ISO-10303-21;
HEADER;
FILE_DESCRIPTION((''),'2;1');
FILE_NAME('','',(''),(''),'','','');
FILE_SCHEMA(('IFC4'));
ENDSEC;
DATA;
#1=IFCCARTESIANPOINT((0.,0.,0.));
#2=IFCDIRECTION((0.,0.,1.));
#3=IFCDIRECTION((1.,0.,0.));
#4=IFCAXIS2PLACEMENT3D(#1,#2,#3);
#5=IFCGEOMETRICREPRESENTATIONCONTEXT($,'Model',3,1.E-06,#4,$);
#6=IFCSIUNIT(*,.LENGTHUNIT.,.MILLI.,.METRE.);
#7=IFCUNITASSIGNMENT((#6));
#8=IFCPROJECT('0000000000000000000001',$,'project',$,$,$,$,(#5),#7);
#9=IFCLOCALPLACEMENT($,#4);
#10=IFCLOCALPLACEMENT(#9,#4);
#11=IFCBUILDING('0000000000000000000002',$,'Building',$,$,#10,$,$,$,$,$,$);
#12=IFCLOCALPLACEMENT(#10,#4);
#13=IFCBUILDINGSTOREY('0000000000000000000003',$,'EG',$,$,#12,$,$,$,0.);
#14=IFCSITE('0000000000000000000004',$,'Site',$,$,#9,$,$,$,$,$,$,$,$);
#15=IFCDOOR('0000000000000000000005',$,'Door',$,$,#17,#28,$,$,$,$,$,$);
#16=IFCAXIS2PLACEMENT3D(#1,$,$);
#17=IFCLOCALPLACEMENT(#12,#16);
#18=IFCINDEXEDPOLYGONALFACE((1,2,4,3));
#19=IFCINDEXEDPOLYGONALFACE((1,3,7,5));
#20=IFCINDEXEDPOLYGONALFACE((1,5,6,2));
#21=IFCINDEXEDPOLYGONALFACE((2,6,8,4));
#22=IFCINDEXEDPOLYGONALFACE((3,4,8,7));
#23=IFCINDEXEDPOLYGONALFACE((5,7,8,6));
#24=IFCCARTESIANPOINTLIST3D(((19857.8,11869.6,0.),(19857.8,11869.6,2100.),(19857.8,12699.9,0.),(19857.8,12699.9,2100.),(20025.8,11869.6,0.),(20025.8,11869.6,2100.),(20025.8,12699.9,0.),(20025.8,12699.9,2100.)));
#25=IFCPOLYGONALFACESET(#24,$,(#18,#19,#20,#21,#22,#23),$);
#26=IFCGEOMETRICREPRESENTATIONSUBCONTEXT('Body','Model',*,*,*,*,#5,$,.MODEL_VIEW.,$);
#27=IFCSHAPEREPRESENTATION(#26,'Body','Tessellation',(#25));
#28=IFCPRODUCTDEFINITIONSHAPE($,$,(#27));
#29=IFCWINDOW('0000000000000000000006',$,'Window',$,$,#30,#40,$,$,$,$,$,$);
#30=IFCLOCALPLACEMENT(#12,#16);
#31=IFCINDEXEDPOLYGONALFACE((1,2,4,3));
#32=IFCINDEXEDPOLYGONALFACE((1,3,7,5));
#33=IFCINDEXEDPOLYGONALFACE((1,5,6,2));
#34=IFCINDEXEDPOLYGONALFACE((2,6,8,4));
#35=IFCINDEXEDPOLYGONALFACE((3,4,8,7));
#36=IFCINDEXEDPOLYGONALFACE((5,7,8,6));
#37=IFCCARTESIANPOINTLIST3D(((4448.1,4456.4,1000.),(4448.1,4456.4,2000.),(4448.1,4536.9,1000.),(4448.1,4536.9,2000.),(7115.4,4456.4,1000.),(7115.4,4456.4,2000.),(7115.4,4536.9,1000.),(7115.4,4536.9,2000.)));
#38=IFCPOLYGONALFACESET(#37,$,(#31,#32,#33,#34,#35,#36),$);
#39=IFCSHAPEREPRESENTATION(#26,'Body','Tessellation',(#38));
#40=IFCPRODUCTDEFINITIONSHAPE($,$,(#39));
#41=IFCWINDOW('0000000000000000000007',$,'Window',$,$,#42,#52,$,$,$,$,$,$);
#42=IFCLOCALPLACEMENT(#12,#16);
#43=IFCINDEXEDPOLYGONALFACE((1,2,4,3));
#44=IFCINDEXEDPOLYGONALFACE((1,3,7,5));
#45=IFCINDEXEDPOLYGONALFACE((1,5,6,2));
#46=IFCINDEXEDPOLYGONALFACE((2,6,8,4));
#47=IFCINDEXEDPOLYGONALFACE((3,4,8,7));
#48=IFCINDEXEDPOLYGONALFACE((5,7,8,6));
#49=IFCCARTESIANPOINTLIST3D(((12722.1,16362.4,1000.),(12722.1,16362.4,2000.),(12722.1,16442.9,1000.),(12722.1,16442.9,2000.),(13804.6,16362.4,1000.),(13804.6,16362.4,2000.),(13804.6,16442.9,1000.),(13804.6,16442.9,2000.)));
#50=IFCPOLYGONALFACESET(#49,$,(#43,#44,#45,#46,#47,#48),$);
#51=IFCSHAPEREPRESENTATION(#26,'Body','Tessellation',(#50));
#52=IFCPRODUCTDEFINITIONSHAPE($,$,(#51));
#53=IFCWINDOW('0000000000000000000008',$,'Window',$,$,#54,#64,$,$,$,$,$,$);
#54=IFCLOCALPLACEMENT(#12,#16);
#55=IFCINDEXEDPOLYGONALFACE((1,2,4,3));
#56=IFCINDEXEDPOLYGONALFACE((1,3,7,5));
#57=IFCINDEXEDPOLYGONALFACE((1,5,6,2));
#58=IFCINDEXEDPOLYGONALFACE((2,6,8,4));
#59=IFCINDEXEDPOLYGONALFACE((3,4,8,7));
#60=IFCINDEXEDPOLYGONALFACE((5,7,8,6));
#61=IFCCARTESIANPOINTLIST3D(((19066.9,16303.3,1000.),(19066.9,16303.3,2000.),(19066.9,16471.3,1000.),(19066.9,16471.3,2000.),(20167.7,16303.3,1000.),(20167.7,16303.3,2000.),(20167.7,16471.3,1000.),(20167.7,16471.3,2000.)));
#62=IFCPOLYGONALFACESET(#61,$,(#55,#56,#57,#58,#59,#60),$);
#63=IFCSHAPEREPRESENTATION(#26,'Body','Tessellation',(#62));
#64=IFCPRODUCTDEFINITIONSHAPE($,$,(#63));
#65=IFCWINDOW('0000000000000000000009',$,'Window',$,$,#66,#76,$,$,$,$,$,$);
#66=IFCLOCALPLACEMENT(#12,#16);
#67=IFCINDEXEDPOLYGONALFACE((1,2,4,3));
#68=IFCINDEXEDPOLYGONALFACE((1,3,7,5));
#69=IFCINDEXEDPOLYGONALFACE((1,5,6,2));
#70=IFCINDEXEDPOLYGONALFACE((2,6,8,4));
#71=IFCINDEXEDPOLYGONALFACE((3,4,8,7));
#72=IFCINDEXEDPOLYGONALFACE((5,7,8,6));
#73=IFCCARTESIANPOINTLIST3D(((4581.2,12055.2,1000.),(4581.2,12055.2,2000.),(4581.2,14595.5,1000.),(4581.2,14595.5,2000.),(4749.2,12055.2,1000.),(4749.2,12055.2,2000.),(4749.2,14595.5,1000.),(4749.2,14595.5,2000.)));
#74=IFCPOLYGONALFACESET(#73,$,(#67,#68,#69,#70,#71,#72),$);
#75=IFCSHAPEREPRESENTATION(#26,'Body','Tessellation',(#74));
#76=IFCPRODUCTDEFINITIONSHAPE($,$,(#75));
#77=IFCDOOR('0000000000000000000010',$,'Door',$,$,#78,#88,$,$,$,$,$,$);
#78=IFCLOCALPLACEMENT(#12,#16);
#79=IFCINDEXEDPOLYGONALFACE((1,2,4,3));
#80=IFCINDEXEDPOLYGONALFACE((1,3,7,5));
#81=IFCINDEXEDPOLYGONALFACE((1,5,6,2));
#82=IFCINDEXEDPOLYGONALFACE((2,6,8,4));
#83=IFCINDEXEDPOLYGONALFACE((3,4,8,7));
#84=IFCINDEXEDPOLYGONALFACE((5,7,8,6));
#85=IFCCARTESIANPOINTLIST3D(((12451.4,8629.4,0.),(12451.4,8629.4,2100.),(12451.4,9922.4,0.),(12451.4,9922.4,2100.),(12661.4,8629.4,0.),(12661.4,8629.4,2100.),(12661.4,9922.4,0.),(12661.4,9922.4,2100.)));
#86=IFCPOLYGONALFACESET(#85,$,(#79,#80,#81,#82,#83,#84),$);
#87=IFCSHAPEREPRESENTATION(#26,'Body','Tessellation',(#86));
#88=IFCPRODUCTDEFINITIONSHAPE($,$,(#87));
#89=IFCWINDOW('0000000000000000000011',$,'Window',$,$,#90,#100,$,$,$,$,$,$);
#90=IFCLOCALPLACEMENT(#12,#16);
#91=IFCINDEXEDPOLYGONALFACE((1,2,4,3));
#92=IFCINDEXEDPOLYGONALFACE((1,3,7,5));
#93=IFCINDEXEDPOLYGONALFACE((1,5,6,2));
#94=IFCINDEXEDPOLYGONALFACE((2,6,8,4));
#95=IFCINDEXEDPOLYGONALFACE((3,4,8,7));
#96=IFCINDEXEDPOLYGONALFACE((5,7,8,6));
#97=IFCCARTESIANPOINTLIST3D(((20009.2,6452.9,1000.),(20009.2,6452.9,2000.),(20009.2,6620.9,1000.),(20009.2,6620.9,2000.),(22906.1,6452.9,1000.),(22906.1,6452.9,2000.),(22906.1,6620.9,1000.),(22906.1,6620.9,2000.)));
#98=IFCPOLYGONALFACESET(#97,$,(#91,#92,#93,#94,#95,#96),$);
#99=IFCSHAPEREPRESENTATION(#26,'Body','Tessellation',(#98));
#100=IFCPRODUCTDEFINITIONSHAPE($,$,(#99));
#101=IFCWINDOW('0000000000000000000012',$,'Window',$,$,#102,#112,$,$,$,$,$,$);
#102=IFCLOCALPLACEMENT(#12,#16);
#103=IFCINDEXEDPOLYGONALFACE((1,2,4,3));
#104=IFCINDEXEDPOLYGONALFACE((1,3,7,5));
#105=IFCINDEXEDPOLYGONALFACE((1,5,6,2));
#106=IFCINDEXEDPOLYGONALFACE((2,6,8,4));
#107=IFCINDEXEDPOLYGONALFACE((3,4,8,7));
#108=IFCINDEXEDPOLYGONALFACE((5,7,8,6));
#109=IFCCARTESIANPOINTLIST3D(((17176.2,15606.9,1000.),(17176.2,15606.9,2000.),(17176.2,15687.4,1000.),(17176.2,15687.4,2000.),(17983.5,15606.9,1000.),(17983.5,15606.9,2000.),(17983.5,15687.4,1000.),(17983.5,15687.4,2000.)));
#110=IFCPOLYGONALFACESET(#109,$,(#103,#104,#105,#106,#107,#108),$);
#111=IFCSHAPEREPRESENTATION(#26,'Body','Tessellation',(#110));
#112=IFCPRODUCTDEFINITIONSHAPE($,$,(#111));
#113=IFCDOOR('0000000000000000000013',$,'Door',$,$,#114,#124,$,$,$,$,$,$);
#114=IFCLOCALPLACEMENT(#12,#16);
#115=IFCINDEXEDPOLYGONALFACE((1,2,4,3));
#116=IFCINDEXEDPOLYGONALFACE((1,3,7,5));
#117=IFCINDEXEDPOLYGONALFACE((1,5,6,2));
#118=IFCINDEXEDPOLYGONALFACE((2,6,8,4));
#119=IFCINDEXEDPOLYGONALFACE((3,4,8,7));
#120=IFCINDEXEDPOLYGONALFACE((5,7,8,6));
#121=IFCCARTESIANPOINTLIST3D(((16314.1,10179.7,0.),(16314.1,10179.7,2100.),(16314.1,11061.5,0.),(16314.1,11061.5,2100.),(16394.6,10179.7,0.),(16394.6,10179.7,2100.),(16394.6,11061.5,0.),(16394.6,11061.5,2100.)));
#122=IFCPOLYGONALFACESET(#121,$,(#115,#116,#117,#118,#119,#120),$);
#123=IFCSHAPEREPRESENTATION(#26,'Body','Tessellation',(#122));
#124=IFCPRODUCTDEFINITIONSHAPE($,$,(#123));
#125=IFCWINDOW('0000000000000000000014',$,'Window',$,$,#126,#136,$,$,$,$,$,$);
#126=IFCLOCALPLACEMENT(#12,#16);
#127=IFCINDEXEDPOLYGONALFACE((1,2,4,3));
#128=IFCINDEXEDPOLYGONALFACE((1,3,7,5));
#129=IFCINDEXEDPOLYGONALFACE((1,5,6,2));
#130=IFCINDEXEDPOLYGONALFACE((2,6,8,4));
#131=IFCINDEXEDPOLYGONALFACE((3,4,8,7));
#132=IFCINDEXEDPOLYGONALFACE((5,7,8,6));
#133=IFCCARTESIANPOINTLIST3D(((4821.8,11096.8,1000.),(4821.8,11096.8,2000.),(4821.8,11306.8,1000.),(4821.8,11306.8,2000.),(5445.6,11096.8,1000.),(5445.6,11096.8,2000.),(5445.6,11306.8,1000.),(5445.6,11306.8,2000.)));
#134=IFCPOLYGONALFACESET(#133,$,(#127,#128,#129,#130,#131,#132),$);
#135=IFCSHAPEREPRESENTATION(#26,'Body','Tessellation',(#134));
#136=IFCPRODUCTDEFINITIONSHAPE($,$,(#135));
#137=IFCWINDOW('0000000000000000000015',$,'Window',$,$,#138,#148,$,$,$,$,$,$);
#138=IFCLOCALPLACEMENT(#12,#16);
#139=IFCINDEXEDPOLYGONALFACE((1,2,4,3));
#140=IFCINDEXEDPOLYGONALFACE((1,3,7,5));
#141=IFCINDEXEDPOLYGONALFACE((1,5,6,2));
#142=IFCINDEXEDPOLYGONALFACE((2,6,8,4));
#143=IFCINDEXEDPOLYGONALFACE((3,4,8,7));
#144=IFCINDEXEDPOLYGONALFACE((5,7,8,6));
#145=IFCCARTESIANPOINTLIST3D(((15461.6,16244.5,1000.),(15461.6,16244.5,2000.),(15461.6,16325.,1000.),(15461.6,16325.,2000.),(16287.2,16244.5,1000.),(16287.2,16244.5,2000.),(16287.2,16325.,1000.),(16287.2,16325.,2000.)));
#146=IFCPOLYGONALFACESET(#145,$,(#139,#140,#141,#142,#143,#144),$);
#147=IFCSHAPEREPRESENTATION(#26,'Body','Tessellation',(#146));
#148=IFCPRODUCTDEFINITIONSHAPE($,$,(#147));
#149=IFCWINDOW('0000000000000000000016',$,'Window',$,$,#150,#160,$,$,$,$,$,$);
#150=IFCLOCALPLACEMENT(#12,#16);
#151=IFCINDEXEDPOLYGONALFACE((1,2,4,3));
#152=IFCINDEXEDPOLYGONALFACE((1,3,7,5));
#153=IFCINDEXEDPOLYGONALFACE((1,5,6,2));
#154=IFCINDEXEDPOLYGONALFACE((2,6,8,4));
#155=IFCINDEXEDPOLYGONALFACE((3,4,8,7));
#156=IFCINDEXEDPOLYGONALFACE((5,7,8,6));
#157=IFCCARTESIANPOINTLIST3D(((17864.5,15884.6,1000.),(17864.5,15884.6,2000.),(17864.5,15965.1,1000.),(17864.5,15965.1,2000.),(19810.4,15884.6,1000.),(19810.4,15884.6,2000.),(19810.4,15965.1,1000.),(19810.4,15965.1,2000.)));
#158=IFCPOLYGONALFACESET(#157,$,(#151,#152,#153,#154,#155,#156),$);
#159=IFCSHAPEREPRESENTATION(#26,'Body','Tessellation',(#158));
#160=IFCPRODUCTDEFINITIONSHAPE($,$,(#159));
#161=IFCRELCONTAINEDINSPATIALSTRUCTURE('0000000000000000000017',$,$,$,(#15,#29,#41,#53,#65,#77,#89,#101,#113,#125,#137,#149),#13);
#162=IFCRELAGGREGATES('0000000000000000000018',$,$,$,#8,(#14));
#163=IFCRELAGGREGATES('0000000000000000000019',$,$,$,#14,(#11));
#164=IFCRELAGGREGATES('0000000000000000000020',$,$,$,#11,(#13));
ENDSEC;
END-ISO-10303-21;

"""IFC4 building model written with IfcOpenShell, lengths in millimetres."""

from ifc_helpers import new_model, si_unit, frame, origin_with_axes, place, context, subcontext, project, spatial, rectangle, extrude, element, save


model = new_model("IFC4")

# Units and contexts
model_context = context("Model", 3, precision=1e-06, world=origin_with_axes())
body_context = subcontext(model_context, "Body", "Model", "MODEL_VIEW")
ifc_project = project(units=[si_unit("LENGTHUNIT", "METRE", prefix="MILLI")], contexts=[model_context])

# Site, building, storey
site_placement = place(None, origin_with_axes())
site = spatial("IfcSite", under=ifc_project, at=site_placement, Name="Site")
building_placement = place(site_placement, origin_with_axes())
building = spatial("IfcBuilding", under=site, at=building_placement, Name="Building")
storey_placement = place(building_placement, origin_with_axes())
storey = spatial("IfcBuildingStorey", under=building, at=storey_placement, Name="EG", Elevation=0.0)

# Door
door_1_placement = place(storey_placement, origin_with_axes())
element("IfcDoor", 1, at=door_1_placement, inside=storey, Name="Door", context=body_context, shape_type="SweptSolid", body=[
    extrude(rectangle(XDim=830.3, YDim=168.0), frame((19941.8, 12284.7, 0.0), z_axis=(0.0, 0.0, 1.0), x_axis=(0.0, 1.0, 0.0)), (0.0, 0.0, 1.0), 2100.0),
])

# Windows
window_1_placement = place(storey_placement, origin_with_axes())
element("IfcWindow", 2, at=window_1_placement, inside=storey, Name="Window", context=body_context, shape_type="SweptSolid", body=[
    extrude(rectangle(XDim=2667.3, YDim=80.5), frame((5781.8, 4496.6, 1000.0), z_axis=(0.0, 0.0, 1.0), x_axis=(1.0, 0.0, 0.0)), (0.0, 0.0, 1.0), 1000.0),
])
window_2_placement = place(storey_placement, origin_with_axes())
element("IfcWindow", 3, at=window_2_placement, inside=storey, Name="Window", context=body_context, shape_type="SweptSolid", body=[
    extrude(rectangle(XDim=1082.5, YDim=80.5), frame((13263.3, 16402.7, 1000.0), z_axis=(0.0, 0.0, 1.0), x_axis=(1.0, 0.0, 0.0)), (0.0, 0.0, 1.0), 1000.0),
])
window_3_placement = place(storey_placement, origin_with_axes())
element("IfcWindow", 4, at=window_3_placement, inside=storey, Name="Window", context=body_context, shape_type="SweptSolid", body=[
    extrude(rectangle(XDim=1100.8, YDim=168.0), frame((19617.3, 16387.3, 1000.0), z_axis=(0.0, 0.0, 1.0), x_axis=(1.0, 0.0, 0.0)), (0.0, 0.0, 1.0), 1000.0),
])
window_4_placement = place(storey_placement, origin_with_axes())
element("IfcWindow", 5, at=window_4_placement, inside=storey, Name="Window", context=body_context, shape_type="SweptSolid", body=[
    extrude(rectangle(XDim=2540.3, YDim=168.0), frame((4665.2, 13325.3, 1000.0), z_axis=(0.0, 0.0, 1.0), x_axis=(0.0, 1.0, 0.0)), (0.0, 0.0, 1.0), 1000.0),
])

# Door
door_2_placement = place(storey_placement, origin_with_axes())
element("IfcDoor", 6, at=door_2_placement, inside=storey, Name="Door", context=body_context, shape_type="SweptSolid", body=[
    extrude(rectangle(XDim=1293.1, YDim=210.0), frame((12556.4, 9275.9, 0.0), z_axis=(0.0, 0.0, 1.0), x_axis=(0.0, 1.0, 0.0)), (0.0, 0.0, 1.0), 2100.0),
])

# Windows
window_5_placement = place(storey_placement, origin_with_axes())
element("IfcWindow", 7, at=window_5_placement, inside=storey, Name="Window", context=body_context, shape_type="SweptSolid", body=[
    extrude(rectangle(XDim=2896.9, YDim=168.0), frame((21457.7, 6536.9, 1000.0), z_axis=(0.0, 0.0, 1.0), x_axis=(1.0, 0.0, 0.0)), (0.0, 0.0, 1.0), 1000.0),
])
window_6_placement = place(storey_placement, origin_with_axes())
element("IfcWindow", 8, at=window_6_placement, inside=storey, Name="Window", context=body_context, shape_type="SweptSolid", body=[
    extrude(rectangle(XDim=807.3, YDim=80.5), frame((17579.9, 15647.1, 1000.0), z_axis=(0.0, 0.0, 1.0), x_axis=(1.0, 0.0, 0.0)), (0.0, 0.0, 1.0), 1000.0),
])

# Door
door_3_placement = place(storey_placement, origin_with_axes())
element("IfcDoor", 9, at=door_3_placement, inside=storey, Name="Door", context=body_context, shape_type="SweptSolid", body=[
    extrude(rectangle(XDim=881.9, YDim=80.5), frame((16354.3, 10620.6, 0.0), z_axis=(0.0, 0.0, 1.0), x_axis=(0.0, 1.0, 0.0)), (0.0, 0.0, 1.0), 2100.0),
])

# Windows
window_7_placement = place(storey_placement, origin_with_axes())
element("IfcWindow", 10, at=window_7_placement, inside=storey, Name="Window", context=body_context, shape_type="SweptSolid", body=[
    extrude(rectangle(XDim=623.8, YDim=210.0), frame((5133.7, 11201.8, 1000.0), z_axis=(0.0, 0.0, 1.0), x_axis=(1.0, 0.0, 0.0)), (0.0, 0.0, 1.0), 1000.0),
])
window_8_placement = place(storey_placement, origin_with_axes())
element("IfcWindow", 11, at=window_8_placement, inside=storey, Name="Window", context=body_context, shape_type="SweptSolid", body=[
    extrude(rectangle(XDim=825.6, YDim=80.5), frame((15874.4, 16284.7, 1000.0), z_axis=(0.0, 0.0, 1.0), x_axis=(1.0, 0.0, 0.0)), (0.0, 0.0, 1.0), 1000.0),
])
window_9_placement = place(storey_placement, origin_with_axes())
element("IfcWindow", 12, at=window_9_placement, inside=storey, Name="Window", context=body_context, shape_type="SweptSolid", body=[
    extrude(rectangle(XDim=1946.0, YDim=80.5), frame((18837.5, 15924.8, 1000.0), z_axis=(0.0, 0.0, 1.0), x_axis=(1.0, 0.0, 0.0)), (0.0, 0.0, 1.0), 1000.0),
])

save(model, "model.ifc")
